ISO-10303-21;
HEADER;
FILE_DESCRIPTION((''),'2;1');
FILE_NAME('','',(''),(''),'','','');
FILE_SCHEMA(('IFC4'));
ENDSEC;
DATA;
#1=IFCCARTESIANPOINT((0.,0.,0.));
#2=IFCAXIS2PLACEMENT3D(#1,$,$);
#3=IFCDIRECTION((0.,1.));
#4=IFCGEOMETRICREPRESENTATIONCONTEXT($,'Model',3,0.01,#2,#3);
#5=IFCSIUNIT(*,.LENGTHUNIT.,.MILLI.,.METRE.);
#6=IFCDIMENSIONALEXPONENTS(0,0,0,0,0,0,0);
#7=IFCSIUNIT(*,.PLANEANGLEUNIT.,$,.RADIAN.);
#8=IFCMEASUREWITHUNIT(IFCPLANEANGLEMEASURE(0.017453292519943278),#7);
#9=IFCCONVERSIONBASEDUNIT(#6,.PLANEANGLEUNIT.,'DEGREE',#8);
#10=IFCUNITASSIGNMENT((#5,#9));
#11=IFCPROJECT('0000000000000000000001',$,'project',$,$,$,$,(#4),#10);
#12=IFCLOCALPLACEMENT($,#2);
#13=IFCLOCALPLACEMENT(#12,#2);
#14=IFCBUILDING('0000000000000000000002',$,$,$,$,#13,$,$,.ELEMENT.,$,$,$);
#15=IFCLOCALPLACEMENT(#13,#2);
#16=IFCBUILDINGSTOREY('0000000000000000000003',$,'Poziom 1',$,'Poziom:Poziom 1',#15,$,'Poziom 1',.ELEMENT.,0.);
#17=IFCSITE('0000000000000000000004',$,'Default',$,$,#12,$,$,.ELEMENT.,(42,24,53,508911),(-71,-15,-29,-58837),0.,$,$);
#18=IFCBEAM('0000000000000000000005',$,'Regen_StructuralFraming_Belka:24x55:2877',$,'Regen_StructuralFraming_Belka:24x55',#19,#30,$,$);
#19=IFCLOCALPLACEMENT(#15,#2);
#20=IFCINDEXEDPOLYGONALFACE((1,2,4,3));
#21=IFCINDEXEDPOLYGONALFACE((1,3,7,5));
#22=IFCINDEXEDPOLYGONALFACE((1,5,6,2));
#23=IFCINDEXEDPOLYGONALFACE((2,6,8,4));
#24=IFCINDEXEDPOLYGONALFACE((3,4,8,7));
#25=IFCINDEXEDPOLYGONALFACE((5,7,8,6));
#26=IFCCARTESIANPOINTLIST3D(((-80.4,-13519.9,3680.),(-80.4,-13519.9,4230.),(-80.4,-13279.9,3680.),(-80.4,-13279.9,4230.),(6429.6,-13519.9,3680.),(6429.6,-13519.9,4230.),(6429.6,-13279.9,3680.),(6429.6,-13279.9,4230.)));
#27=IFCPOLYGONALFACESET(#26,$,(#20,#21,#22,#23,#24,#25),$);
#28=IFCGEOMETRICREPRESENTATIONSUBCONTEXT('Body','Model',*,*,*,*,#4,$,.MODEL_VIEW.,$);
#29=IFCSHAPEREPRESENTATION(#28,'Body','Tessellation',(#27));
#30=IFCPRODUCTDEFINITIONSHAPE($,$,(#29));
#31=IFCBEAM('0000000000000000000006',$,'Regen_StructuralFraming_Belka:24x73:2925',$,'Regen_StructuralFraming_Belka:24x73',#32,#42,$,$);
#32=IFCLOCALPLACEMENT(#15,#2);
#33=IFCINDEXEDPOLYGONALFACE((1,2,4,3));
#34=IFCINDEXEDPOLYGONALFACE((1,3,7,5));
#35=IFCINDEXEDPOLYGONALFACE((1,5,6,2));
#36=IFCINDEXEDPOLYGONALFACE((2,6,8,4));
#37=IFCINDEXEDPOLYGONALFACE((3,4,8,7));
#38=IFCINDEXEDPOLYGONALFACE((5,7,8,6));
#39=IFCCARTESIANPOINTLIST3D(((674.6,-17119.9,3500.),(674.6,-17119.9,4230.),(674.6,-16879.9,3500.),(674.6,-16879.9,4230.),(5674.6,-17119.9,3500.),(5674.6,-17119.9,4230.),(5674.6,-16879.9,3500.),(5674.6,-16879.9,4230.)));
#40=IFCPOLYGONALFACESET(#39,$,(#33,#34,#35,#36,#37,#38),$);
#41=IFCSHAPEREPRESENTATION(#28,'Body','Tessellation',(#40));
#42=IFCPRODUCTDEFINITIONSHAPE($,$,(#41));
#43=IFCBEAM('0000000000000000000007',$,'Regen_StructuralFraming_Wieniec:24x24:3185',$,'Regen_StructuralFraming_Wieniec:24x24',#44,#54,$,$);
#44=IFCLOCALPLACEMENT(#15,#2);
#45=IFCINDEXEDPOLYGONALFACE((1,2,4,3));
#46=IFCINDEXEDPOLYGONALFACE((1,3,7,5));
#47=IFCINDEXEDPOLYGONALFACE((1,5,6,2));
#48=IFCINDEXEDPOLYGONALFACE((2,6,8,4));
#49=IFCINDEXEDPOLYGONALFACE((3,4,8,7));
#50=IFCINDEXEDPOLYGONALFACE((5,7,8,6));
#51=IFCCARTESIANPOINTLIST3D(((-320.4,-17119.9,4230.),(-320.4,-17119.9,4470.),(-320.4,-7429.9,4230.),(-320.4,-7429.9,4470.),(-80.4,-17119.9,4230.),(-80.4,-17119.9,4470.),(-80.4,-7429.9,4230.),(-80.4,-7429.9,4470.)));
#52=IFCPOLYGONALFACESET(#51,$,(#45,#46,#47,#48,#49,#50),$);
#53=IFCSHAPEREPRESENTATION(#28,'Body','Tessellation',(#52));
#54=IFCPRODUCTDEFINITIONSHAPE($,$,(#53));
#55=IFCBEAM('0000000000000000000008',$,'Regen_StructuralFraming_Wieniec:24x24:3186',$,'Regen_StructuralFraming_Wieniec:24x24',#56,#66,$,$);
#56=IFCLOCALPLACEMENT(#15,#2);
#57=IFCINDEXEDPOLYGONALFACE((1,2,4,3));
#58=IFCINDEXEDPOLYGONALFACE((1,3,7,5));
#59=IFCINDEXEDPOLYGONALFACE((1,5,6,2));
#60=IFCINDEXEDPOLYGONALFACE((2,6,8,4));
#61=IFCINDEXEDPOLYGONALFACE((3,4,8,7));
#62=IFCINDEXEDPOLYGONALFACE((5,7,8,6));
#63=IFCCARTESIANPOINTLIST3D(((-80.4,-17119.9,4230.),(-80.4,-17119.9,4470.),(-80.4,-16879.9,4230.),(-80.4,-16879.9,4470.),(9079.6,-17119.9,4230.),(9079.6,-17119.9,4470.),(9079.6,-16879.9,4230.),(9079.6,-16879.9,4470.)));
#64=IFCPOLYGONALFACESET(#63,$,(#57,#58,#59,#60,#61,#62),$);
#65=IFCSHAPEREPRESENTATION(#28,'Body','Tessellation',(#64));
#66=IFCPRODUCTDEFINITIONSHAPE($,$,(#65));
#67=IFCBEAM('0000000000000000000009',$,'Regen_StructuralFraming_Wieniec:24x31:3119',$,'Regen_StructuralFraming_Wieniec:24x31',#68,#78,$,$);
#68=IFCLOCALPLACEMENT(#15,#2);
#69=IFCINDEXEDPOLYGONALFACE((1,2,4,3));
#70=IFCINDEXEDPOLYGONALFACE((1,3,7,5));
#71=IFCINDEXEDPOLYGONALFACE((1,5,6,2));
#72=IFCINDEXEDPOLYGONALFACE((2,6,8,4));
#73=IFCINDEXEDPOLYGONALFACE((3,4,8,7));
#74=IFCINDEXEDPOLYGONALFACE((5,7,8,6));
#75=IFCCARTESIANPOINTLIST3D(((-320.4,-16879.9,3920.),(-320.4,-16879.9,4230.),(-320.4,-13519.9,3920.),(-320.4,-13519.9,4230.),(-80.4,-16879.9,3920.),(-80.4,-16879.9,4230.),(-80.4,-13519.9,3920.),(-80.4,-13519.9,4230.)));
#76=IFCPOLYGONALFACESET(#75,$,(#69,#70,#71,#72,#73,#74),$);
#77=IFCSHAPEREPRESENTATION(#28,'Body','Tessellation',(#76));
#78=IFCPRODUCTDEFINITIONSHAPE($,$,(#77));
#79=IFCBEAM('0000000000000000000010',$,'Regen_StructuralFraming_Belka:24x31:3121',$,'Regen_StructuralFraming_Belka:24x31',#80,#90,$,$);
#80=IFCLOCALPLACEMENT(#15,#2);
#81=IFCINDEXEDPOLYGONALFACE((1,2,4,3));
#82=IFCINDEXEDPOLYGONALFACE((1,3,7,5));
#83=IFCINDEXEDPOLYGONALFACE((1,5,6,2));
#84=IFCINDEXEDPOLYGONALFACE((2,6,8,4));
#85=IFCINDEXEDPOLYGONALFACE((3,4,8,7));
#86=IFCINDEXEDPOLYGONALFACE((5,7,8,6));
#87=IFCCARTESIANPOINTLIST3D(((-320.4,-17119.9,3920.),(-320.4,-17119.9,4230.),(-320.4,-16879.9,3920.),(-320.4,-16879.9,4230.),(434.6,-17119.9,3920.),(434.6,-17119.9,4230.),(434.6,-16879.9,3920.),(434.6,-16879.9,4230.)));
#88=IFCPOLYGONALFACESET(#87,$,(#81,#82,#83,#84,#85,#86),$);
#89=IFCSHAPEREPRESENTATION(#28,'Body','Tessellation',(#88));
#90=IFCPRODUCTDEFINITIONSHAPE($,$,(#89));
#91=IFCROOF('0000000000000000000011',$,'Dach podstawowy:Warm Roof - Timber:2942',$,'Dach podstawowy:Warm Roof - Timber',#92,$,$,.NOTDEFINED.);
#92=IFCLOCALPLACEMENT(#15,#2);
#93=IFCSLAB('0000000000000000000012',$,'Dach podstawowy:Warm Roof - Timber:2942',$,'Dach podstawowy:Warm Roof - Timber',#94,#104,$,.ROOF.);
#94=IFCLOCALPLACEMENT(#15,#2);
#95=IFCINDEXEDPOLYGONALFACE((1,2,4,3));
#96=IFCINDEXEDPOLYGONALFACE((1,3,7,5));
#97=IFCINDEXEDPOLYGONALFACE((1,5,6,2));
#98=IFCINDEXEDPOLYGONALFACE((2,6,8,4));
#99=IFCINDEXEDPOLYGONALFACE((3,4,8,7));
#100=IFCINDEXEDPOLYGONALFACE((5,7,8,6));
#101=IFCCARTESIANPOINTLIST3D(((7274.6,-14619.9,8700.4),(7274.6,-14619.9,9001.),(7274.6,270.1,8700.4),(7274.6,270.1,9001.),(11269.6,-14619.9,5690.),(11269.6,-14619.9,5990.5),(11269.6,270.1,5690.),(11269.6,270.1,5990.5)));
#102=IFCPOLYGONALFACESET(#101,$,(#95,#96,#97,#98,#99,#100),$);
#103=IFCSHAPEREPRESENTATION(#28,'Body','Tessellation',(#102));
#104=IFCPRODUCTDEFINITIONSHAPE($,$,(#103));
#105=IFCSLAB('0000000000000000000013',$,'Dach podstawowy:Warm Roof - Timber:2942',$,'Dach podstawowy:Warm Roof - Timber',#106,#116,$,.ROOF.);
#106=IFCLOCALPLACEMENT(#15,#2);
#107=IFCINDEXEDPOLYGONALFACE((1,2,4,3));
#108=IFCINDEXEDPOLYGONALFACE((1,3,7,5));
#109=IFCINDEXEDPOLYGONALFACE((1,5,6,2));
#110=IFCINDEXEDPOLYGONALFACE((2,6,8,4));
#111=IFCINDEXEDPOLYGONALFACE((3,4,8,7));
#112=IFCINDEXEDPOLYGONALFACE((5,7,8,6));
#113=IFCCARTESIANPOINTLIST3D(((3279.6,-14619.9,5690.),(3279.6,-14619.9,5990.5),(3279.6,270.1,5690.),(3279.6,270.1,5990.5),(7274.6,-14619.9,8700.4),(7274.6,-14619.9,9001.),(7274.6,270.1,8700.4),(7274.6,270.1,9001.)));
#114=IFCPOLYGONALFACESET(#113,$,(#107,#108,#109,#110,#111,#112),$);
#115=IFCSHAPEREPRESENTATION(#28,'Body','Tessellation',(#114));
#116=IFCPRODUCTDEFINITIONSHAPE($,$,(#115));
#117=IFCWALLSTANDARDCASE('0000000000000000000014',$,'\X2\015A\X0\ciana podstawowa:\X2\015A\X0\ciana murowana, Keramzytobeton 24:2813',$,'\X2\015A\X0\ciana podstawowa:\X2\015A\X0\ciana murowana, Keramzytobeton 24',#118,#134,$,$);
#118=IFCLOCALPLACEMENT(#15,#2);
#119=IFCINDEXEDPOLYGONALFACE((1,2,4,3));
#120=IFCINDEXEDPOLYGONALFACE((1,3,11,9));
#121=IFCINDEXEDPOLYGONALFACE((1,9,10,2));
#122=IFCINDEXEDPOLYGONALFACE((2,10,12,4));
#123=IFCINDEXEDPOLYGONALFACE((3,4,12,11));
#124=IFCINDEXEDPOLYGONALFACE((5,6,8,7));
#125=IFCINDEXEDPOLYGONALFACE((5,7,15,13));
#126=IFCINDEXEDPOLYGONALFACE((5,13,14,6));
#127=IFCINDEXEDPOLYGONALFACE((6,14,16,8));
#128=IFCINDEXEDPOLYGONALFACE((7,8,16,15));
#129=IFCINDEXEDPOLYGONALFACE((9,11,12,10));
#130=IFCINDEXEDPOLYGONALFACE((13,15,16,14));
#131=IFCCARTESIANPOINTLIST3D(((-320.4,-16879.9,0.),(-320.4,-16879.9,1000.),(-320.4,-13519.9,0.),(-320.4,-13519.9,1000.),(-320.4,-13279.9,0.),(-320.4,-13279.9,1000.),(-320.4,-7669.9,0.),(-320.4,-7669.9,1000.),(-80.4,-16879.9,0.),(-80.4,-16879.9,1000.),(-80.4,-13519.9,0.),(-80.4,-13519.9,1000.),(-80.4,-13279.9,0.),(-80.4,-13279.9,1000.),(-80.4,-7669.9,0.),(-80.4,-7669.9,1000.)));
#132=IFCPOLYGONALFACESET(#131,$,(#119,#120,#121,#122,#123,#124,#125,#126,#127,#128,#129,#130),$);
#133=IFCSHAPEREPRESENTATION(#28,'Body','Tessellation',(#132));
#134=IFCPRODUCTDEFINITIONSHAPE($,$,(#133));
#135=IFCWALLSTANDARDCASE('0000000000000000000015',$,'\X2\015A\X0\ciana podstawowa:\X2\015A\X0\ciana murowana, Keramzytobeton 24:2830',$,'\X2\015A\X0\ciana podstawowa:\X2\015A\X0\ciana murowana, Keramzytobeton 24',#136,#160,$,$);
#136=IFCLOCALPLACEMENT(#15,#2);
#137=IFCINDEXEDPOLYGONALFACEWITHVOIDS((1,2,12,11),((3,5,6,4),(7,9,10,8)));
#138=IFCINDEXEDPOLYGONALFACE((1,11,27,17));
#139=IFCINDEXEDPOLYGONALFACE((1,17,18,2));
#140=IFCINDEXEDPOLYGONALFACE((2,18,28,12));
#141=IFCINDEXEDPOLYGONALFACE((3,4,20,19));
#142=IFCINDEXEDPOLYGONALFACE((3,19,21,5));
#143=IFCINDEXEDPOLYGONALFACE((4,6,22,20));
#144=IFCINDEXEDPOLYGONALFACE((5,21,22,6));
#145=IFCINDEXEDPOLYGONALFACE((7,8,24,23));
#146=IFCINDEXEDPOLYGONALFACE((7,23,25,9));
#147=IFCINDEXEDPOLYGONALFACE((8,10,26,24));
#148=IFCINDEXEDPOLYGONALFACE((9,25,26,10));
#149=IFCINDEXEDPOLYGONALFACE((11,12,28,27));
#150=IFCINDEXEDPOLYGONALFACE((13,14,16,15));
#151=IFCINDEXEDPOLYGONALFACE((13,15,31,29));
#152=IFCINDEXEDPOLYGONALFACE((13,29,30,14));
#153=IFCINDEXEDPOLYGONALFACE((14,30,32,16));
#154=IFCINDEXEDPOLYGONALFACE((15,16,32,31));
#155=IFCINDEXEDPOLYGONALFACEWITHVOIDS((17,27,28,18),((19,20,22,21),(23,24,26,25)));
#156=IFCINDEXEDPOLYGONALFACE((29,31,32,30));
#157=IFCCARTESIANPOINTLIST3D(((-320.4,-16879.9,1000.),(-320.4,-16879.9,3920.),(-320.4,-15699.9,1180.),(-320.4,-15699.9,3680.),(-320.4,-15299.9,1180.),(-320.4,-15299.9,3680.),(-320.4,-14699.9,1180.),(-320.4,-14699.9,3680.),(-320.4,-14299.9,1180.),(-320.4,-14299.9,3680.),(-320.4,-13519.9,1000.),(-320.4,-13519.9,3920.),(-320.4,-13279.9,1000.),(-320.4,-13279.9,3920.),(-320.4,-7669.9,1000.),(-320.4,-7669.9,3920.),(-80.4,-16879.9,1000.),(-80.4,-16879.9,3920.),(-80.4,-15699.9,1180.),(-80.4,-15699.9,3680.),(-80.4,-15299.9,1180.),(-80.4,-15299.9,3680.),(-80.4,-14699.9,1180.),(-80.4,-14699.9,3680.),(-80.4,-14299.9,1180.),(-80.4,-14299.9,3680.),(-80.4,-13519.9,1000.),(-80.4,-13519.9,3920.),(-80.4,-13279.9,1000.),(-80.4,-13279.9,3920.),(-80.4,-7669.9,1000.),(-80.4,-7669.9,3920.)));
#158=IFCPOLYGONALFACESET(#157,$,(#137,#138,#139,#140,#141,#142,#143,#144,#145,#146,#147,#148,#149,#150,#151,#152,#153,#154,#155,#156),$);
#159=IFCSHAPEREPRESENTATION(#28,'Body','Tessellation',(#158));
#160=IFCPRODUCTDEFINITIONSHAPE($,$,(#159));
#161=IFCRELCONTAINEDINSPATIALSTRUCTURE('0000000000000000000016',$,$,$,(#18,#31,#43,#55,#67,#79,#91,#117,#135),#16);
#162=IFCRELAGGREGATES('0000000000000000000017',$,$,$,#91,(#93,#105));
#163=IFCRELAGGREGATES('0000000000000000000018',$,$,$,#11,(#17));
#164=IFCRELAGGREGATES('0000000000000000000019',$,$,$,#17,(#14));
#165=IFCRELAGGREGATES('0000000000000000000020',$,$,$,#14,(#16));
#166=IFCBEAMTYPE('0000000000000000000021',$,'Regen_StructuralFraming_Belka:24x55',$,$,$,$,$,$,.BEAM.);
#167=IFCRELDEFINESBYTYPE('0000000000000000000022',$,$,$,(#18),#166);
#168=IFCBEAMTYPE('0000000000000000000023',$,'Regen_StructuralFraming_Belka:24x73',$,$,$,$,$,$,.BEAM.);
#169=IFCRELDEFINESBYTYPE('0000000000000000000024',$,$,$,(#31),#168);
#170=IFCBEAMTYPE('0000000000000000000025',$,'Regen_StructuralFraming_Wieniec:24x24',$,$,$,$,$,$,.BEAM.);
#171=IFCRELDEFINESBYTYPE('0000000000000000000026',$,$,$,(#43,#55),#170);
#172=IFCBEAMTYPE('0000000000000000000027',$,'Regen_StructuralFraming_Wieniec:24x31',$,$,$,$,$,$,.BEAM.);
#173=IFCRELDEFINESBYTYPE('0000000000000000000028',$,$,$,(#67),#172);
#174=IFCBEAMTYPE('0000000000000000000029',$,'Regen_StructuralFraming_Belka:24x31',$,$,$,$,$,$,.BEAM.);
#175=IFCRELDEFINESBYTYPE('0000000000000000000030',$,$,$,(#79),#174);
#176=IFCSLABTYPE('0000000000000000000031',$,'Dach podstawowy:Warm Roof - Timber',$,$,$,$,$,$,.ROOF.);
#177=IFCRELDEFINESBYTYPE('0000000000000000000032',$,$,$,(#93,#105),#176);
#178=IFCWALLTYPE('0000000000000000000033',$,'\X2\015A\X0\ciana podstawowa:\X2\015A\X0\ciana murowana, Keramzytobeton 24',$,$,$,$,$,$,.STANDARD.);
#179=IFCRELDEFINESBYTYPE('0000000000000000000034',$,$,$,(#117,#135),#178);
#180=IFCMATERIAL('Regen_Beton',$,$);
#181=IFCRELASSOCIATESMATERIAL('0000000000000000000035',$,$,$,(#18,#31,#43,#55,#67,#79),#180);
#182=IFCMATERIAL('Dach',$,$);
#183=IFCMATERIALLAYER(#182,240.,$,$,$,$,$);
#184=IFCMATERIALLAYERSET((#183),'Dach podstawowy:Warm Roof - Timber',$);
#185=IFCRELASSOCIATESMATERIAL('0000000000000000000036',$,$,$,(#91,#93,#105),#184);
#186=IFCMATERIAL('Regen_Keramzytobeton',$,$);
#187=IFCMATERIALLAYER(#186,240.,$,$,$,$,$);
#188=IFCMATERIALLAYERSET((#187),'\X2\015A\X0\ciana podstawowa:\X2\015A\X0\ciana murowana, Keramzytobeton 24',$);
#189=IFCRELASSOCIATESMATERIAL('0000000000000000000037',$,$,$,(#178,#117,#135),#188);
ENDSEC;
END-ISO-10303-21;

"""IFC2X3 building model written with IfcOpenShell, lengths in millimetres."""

from ifc_helpers import new_model, entity, si_unit, converted_unit, direction, frame, frame_2d, origin, origin_2d_with_axis, place, context, subcontext, project, spatial, rectangle, extrude, material, layer, layer_set, layer_usage, type_object, element, aggregate, save


model = new_model("IFC2X3")

# Units and contexts
model_context = context("Model", 3, precision=0.01, world=origin(), true_north=direction((0.0, 1.0)))
body_context = subcontext(model_context, "Body", "Model", "MODEL_VIEW")
ifc_project = project(units=[si_unit("LENGTHUNIT", "METRE", prefix="MILLI"), converted_unit("PLANEANGLEUNIT", "DEGREE", entity("IfcPlaneAngleMeasure", 0.017453292519943278), si_unit("PLANEANGLEUNIT", "RADIAN"), dimensions=[0, 0, 0, 0, 0, 0, 0])], contexts=[model_context])

# Site, building, storey
site_placement = place(None, origin())
site = spatial("IfcSite", under=ifc_project, at=site_placement, Name="Default", CompositionType="ELEMENT", RefLatitude=(42, 24, 53, 508911), RefLongitude=(-71, -15, -29, -58837), RefElevation=0.0)
building_placement = place(site_placement, origin())
building = spatial("IfcBuilding", under=site, at=building_placement, CompositionType="ELEMENT")
storey_placement = place(building_placement, origin())
storey = spatial("IfcBuildingStorey", under=building, at=storey_placement, Name="Poziom 1", ObjectType="Poziom:Poziom 1", LongName="Poziom 1", CompositionType="ELEMENT", Elevation=0.0)

# Beams
ifc_material_1 = material(Name="Regen_Beton")
beam_type_1 = type_object("IfcBeamType", Name="Regen_StructuralFraming_Belka:24x55", PredefinedType="BEAM")
beam_1_placement = place(storey_placement, frame((-80.4, -13399.9, 4230.0)))
element("IfcBeam", 1, at=beam_1_placement, inside=storey, type_object=beam_type_1, material=ifc_material_1, Name="Regen_StructuralFraming_Belka:24x55:2877", ObjectType="Regen_StructuralFraming_Belka:24x55", context=body_context, shape_type="SweptSolid", body=[
    extrude(rectangle(XDim=550.0, YDim=240.0, at=frame_2d((0.0, 0.0), x_axis=(1.0, 0.0))), frame((0.0, 0.0, -275.0), z_axis=(1.0, 0.0, 0.0), x_axis=(0.0, 0.0, -1.0)), (0.0, 0.0, 1.0), 6510.0),
])
beam_type_2 = type_object("IfcBeamType", Name="Regen_StructuralFraming_Belka:24x73", PredefinedType="BEAM")
beam_2_placement = place(storey_placement, frame((674.6, -16999.9, 4230.0)))
element("IfcBeam", 2, at=beam_2_placement, inside=storey, type_object=beam_type_2, material=ifc_material_1, Name="Regen_StructuralFraming_Belka:24x73:2925", ObjectType="Regen_StructuralFraming_Belka:24x73", context=body_context, shape_type="SweptSolid", body=[
    extrude(rectangle(XDim=730.0, YDim=240.0, at=frame_2d((0.0, 0.0), x_axis=(1.0, 0.0))), frame((0.0, 0.0, -365.0), z_axis=(1.0, 0.0, 0.0), x_axis=(0.0, 0.0, -1.0)), (0.0, 0.0, 1.0), 5000.0),
])
beam_type_3 = type_object("IfcBeamType", Name="Regen_StructuralFraming_Wieniec:24x24", PredefinedType="BEAM")
beam_3_placement = place(storey_placement, frame((-200.4, -16999.9, 4230.0), z_axis=(0.0, 0.0, 1.0), x_axis=(0.0, 1.0, 0.0)))
element("IfcBeam", 3, at=beam_3_placement, inside=storey, type_object=beam_type_3, material=ifc_material_1, Name="Regen_StructuralFraming_Wieniec:24x24:3185", ObjectType="Regen_StructuralFraming_Wieniec:24x24", context=body_context, shape_type="SweptSolid", body=[
    extrude(rectangle(XDim=240.0, YDim=240.0, at=origin_2d_with_axis()), frame((-120.0, 0.0, 120.0), z_axis=(1.0, 0.0, 0.0), x_axis=(0.0, 0.0, -1.0)), (0.0, 0.0, 1.0), 9690.0),
])
beam_4_placement = place(storey_placement, frame((-200.4, -16999.9, 4230.0)))
element("IfcBeam", 4, at=beam_4_placement, inside=storey, type_object=beam_type_3, material=ifc_material_1, Name="Regen_StructuralFraming_Wieniec:24x24:3186", ObjectType="Regen_StructuralFraming_Wieniec:24x24", context=body_context, shape_type="SweptSolid", body=[
    extrude(rectangle(XDim=240.0, YDim=240.0, at=origin_2d_with_axis()), frame((120.0, 0.0, 120.0), z_axis=(1.0, 0.0, 0.0), x_axis=(0.0, 0.0, -1.0)), (0.0, 0.0, 1.0), 9160.0),
])
beam_type_4 = type_object("IfcBeamType", Name="Regen_StructuralFraming_Wieniec:24x31", PredefinedType="BEAM")
beam_5_placement = place(storey_placement, frame((-200.4, -16879.9, 4230.0), z_axis=(0.0, 0.0, 1.0), x_axis=(0.0, 1.0, 0.0)))
element("IfcBeam", 5, at=beam_5_placement, inside=storey, type_object=beam_type_4, material=ifc_material_1, Name="Regen_StructuralFraming_Wieniec:24x31:3119", ObjectType="Regen_StructuralFraming_Wieniec:24x31", context=body_context, shape_type="SweptSolid", body=[
    extrude(rectangle(XDim=310.0, YDim=240.0, at=frame_2d((0.0, 0.0), x_axis=(1.0, 0.0))), frame((0.0, 0.0, -155.0), z_axis=(1.0, 0.0, 0.0), x_axis=(0.0, 0.0, -1.0)), (0.0, 0.0, 1.0), 3360.0),
])
beam_type_5 = type_object("IfcBeamType", Name="Regen_StructuralFraming_Belka:24x31", PredefinedType="BEAM")
beam_6_placement = place(storey_placement, frame((434.6, -16999.9, 4230.0), z_axis=(0.0, 0.0, 1.0), x_axis=(-1.0, 0.0, 0.0)))
element("IfcBeam", 6, at=beam_6_placement, inside=storey, type_object=beam_type_5, material=ifc_material_1, Name="Regen_StructuralFraming_Belka:24x31:3121", ObjectType="Regen_StructuralFraming_Belka:24x31", context=body_context, shape_type="SweptSolid", body=[
    extrude(rectangle(XDim=310.0, YDim=240.0, at=frame_2d((0.0, 0.0), x_axis=(1.0, 0.0))), frame((0.0, 0.0, -155.0), z_axis=(1.0, 0.0, 0.0), x_axis=(0.0, 0.0, -1.0)), (0.0, 0.0, 1.0), 755.0),
])

# Roof, slabs
ifc_material_2 = material(Name="Dach")
ifc_layer_1 = layer(ifc_material_2, 240.0)
ifc_layer_set_1 = layer_set([ifc_layer_1], Name="Dach podstawowy:Warm Roof - Timber")
roof_placement = place(storey_placement, frame((3279.6, -14619.9, 5690.0)))
roof = element("IfcRoof", 7, at=roof_placement, inside=storey, material=ifc_layer_set_1, Name="Dach podstawowy:Warm Roof - Timber:2942", ObjectType="Dach podstawowy:Warm Roof - Timber", ShapeType="NOTDEFINED")
slab_type_1 = type_object("IfcSlabType", Name="Dach podstawowy:Warm Roof - Timber", PredefinedType="ROOF")
slab_1_placement = place(roof_placement, origin())
slab_1 = element("IfcSlab", 8, at=slab_1_placement, type_object=slab_type_1, material=ifc_layer_set_1, Name="Dach podstawowy:Warm Roof - Timber:2942", ObjectType="Dach podstawowy:Warm Roof - Timber", PredefinedType="ROOF", context=body_context, shape_type="SweptSolid", body=[
    extrude(rectangle(XDim=5002.3, YDim=14890.0, at=origin_2d_with_axis()), frame((5992.5, 7445.0, 1505.2), z_axis=(0.601815, 0.0, 0.798636), x_axis=(0.798636, 0.0, -0.601815)), (-0.601815, 0.0, 0.798636), 300.5),
])
slab_2_placement = place(roof_placement, origin())
slab_2 = element("IfcSlab", 9, at=slab_2_placement, type_object=slab_type_1, material=ifc_layer_set_1, Name="Dach podstawowy:Warm Roof - Timber:2942", ObjectType="Dach podstawowy:Warm Roof - Timber", PredefinedType="ROOF", context=body_context, shape_type="SweptSolid", body=[
    extrude(rectangle(XDim=14890.0, YDim=5002.3, at=frame_2d((0.0, 0.0), x_axis=(0.0, 1.0))), frame((1997.5, 7445.0, 1505.2), z_axis=(-0.601815, 0.0, 0.798636), x_axis=(0.798636, 0.0, 0.601815)), (0.601815, 0.0, 0.798636), 300.5),
])
aggregate(roof, [slab_1, slab_2])

# Wall, opening
ifc_material_3 = material(Name="Regen_Keramzytobeton")
ifc_layer_2 = layer(ifc_material_3, 240.0)
ifc_layer_set_2 = layer_set([ifc_layer_2], Name="Ściana podstawowa:Ściana murowana, Keramzytobeton 24")
ifc_layer_usage_1 = layer_usage(ifc_layer_set_2, "AXIS2", "NEGATIVE", 120.0)
wall_type = type_object("IfcWallType", Name="Ściana podstawowa:Ściana murowana, Keramzytobeton 24", PredefinedType="STANDARD", material=ifc_layer_set_2)
wall_1_placement = place(storey_placement, frame((-200.4, -16879.9, 0.0), z_axis=(0.0, 0.0, 1.0), x_axis=(0.0, 1.0, 0.0)))
wall_1 = element("IfcWallStandardCase", 10, at=wall_1_placement, inside=storey, type_object=wall_type, material=ifc_layer_usage_1, Name="Ściana podstawowa:Ściana murowana, Keramzytobeton 24:2813", ObjectType="Ściana podstawowa:Ściana murowana, Keramzytobeton 24", context=body_context, shape_type="SweptSolid", body=[
    extrude(rectangle(XDim=9210.0, YDim=240.0, at=frame_2d((4605.0, 0.0), x_axis=(-1.0, 0.0))), origin(), (0.0, 0.0, 1.0), 1000.0),
])
opening_1_placement = place(storey_placement, frame((-200.4, -16879.9, 0.0), z_axis=(0.0, 0.0, 1.0), x_axis=(0.0, 1.0, 0.0)))
element("IfcOpeningElement", 11, at=opening_1_placement, cuts=wall_1, ObjectType="Opening", context=body_context, shape_type="SweptSolid", body=[
    extrude(rectangle(XDim=1000.0, YDim=240.0, at=origin_2d_with_axis()), frame((3360.0, 0.0, 500.0), z_axis=(1.0, 0.0, 0.0), x_axis=(0.0, 0.0, -1.0)), (0.0, 0.0, 1.0), 240.0),
])

# Wall, openings
ifc_layer_usage_2 = layer_usage(ifc_layer_set_2, "AXIS2", "NEGATIVE", 120.0)
wall_2_placement = place(storey_placement, frame((-200.4, -16879.9, 1000.0), z_axis=(0.0, 0.0, 1.0), x_axis=(0.0, 1.0, 0.0)))
wall_2 = element("IfcWallStandardCase", 12, at=wall_2_placement, inside=storey, type_object=wall_type, material=ifc_layer_usage_2, Name="Ściana podstawowa:Ściana murowana, Keramzytobeton 24:2830", ObjectType="Ściana podstawowa:Ściana murowana, Keramzytobeton 24", context=body_context, shape_type="SweptSolid", body=[
    extrude(rectangle(XDim=9210.0, YDim=240.0, at=frame_2d((4605.0, 0.0), x_axis=(1.0, 0.0))), origin(), (0.0, 0.0, 1.0), 2920.0),
])
opening_2_placement = place(storey_placement, frame((-200.4, -16879.9, 1000.0), z_axis=(0.0, 0.0, 1.0), x_axis=(0.0, 1.0, 0.0)))
element("IfcOpeningElement", 13, at=opening_2_placement, cuts=wall_2, ObjectType="Opening", context=body_context, shape_type="SweptSolid", body=[
    extrude(rectangle(XDim=2920.0, YDim=240.0, at=frame_2d((0.0, 0.0), x_axis=(1.0, 0.0))), frame((3360.0, 0.0, 1460.0), z_axis=(1.0, 0.0, 0.0), x_axis=(0.0, 0.0, -1.0)), (0.0, 0.0, 1.0), 240.0),
])
opening_3_placement = place(wall_2_placement, frame((16879.9, -200.4, -1000.0), z_axis=(0.0, 0.0, 1.0), x_axis=(0.0, -1.0, 0.0)))
element("IfcOpeningElement", 14, at=opening_3_placement, cuts=wall_2, ObjectType="Opening", context=body_context, shape_type="SweptSolid", body=[
    extrude(rectangle(XDim=2500.0, YDim=400.0, at=frame_2d((0.0, 0.0), x_axis=(1.0, 0.0))), frame((1203.6, -15499.9, 2430.0), z_axis=(-1.0, 0.0, 0.0), x_axis=(0.0, 0.0, -1.0)), (0.0, 0.0, 1.0), 3048.0),
])
opening_4_placement = place(wall_2_placement, frame((16879.9, -200.4, -1000.0), z_axis=(0.0, 0.0, 1.0), x_axis=(0.0, -1.0, 0.0)))
element("IfcOpeningElement", 15, at=opening_4_placement, cuts=wall_2, ObjectType="Opening", context=body_context, shape_type="SweptSolid", body=[
    extrude(rectangle(XDim=2500.0, YDim=400.0, at=origin_2d_with_axis()), frame((1203.6, -14499.9, 2430.0), z_axis=(-1.0, 0.0, 0.0), x_axis=(0.0, 0.0, -1.0)), (0.0, 0.0, 1.0), 3048.0),
])

save(model, "model.ifc")
